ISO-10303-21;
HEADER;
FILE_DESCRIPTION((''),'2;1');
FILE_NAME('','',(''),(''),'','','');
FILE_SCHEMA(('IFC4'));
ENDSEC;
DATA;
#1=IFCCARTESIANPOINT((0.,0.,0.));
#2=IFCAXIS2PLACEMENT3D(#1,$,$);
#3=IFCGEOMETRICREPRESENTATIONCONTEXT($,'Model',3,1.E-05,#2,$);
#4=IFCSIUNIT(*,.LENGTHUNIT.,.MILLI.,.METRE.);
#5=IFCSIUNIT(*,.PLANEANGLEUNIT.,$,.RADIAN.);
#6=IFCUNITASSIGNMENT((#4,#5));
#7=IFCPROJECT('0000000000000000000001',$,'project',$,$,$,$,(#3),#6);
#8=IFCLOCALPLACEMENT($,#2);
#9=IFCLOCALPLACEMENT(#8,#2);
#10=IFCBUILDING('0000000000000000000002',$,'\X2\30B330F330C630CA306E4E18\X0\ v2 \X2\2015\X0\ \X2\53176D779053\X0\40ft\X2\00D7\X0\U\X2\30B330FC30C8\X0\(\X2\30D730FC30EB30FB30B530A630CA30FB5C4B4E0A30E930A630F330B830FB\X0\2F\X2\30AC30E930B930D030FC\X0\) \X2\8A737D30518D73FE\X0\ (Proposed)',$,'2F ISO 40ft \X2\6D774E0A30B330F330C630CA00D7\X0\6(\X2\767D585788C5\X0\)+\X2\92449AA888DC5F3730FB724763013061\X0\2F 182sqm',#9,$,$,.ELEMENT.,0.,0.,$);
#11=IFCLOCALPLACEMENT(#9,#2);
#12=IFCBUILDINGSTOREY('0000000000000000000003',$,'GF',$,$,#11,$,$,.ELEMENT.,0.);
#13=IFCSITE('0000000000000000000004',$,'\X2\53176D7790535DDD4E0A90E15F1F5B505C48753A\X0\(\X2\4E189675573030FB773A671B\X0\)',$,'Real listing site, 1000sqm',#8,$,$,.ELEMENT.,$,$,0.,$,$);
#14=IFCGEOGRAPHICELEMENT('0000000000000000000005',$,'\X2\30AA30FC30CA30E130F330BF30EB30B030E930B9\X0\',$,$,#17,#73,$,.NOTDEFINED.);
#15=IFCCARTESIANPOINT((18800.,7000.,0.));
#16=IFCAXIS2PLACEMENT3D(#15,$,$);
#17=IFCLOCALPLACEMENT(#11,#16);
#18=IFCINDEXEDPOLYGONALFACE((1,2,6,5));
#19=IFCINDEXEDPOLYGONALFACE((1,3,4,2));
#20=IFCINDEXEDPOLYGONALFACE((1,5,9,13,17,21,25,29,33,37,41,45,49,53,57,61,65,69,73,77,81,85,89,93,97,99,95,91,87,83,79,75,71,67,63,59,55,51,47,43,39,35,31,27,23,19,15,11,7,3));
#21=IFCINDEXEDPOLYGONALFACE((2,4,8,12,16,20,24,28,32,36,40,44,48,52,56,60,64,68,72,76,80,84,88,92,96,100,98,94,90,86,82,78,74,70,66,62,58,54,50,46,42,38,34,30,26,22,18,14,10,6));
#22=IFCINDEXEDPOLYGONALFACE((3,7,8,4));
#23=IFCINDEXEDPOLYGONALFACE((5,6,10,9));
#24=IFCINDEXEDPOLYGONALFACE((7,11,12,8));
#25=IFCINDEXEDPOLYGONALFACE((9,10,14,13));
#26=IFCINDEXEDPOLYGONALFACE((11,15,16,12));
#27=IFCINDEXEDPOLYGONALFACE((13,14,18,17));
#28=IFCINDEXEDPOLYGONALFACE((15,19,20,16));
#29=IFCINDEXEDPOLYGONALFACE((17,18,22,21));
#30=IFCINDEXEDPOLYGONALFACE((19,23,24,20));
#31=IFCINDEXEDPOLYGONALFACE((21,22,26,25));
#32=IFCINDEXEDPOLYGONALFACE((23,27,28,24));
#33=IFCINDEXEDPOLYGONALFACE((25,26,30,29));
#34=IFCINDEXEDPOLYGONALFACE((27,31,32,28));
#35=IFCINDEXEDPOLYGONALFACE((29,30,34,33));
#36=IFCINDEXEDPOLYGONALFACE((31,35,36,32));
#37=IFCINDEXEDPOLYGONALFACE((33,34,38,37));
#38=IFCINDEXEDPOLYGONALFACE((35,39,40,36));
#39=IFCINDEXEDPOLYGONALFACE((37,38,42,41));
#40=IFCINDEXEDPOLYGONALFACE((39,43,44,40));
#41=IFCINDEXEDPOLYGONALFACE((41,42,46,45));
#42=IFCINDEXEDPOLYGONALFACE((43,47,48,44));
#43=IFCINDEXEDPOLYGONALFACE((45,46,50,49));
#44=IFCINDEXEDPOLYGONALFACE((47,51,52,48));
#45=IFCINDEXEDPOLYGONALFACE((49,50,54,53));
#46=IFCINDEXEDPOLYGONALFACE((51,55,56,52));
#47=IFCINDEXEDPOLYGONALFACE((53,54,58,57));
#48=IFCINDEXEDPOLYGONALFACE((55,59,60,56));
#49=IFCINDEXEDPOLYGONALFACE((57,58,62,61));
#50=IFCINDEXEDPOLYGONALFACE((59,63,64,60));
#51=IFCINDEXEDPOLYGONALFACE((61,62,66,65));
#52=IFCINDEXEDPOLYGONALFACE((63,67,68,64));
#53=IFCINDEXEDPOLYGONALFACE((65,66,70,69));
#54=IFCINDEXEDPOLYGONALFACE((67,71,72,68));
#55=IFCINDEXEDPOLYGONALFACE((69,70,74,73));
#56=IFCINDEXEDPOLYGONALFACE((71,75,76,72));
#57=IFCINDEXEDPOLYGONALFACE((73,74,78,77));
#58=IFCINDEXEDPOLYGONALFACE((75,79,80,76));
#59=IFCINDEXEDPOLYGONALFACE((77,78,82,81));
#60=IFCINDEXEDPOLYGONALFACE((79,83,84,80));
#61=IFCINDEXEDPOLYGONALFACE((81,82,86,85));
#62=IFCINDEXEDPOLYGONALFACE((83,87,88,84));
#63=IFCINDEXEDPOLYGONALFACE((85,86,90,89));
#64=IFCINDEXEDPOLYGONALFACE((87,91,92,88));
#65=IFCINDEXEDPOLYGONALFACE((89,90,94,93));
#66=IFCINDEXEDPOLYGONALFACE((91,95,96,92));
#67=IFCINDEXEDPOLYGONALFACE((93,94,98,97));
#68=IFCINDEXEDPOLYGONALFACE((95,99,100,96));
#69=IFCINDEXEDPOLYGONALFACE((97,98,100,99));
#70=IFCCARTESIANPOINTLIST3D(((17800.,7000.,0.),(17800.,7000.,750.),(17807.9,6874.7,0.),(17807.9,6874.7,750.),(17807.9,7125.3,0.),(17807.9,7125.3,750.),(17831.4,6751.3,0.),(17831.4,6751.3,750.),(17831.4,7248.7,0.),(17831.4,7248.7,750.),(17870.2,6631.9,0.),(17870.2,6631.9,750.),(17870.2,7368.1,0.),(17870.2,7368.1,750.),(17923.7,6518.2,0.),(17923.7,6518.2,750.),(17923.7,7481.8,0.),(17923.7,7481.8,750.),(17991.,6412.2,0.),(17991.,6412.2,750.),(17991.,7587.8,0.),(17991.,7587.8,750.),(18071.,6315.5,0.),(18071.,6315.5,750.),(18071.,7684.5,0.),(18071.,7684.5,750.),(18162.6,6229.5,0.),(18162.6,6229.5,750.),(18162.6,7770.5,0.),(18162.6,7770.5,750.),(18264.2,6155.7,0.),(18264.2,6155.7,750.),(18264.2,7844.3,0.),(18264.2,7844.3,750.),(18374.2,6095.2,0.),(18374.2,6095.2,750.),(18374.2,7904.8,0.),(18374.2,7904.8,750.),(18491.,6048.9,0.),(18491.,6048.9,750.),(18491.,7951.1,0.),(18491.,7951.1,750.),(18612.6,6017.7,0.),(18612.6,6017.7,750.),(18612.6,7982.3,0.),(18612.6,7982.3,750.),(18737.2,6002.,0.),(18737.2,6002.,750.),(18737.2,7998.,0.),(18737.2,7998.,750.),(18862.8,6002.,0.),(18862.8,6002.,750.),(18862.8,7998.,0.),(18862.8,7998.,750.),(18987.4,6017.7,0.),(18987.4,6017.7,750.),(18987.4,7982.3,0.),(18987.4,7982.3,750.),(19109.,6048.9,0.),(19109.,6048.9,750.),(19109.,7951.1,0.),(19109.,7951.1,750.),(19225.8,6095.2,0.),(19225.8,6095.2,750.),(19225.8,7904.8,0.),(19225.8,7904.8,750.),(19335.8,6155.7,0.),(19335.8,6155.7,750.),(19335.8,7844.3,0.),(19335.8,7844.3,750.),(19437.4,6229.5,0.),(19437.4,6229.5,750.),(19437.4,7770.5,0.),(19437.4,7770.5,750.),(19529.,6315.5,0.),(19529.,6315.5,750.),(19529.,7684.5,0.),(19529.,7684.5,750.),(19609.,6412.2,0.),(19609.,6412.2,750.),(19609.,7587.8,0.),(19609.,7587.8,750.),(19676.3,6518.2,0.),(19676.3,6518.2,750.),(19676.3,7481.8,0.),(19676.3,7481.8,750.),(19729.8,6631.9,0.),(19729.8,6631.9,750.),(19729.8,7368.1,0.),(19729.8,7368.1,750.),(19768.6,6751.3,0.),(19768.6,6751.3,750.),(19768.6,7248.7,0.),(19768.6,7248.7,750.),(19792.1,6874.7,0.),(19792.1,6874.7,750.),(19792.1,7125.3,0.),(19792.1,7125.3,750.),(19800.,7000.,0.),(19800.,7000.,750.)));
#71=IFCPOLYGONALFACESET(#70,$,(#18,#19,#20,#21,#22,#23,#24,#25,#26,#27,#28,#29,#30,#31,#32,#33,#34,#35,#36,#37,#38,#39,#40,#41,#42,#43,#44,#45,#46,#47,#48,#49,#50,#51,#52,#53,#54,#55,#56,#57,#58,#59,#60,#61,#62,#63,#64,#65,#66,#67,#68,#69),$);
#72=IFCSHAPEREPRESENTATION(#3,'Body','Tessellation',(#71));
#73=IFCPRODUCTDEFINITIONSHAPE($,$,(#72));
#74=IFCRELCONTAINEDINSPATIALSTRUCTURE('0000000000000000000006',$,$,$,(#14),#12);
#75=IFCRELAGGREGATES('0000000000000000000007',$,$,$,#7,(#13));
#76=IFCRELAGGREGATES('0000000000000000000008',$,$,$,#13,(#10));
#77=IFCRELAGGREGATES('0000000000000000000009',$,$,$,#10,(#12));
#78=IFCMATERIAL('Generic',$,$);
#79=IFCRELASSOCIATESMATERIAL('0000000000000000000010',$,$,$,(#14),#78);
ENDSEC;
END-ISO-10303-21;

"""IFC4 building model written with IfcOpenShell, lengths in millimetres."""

from ifc_helpers import new_model, si_unit, frame, origin, origin_2d, place, context, project, spatial, circle, extrude, material, element, save


model = new_model("IFC4")

# Units and contexts
model_context = context("Model", 3, precision=1e-05, world=origin())
ifc_project = project(units=[si_unit("LENGTHUNIT", "METRE", prefix="MILLI"), si_unit("PLANEANGLEUNIT", "RADIAN")], contexts=[model_context])

# Site, building, storey
site_placement = place(None, origin())
site = spatial("IfcSite", under=ifc_project, at=site_placement, Name="北海道川上郡弟子屈町(丘陵地・眺望)", ObjectType="Real listing site, 1000sqm", CompositionType="ELEMENT", RefElevation=0.0)
building_placement = place(site_placement, origin())
building = spatial("IfcBuilding", under=site, at=building_placement, Name="コンテナの丘 v2 ― 北海道40ft×Uコート(プール・サウナ・屋上ラウンジ・2Fガラスバー) 詳細再現 (Proposed)", ObjectType="2F ISO 40ft 海上コンテナ×6(白塗装)+鉄骨補強・片持ち2F 182sqm", CompositionType="ELEMENT", ElevationOfRefHeight=0.0, ElevationOfTerrain=0.0)
storey_placement = place(building_placement, origin())
storey = spatial("IfcBuildingStorey", under=building, at=storey_placement, Name="GF", CompositionType="ELEMENT", Elevation=0.0)

# Shared definitions
ifc_material = material(Name="Generic")

# Geographic element
geographic_element_1_placement = place(storey_placement, frame((18800.0, 7000.0, 0.0)))
element("IfcGeographicElement", 1, at=geographic_element_1_placement, inside=storey, material=ifc_material, Name="オーナメンタルグラス", PredefinedType="NOTDEFINED", context=model_context, shape_type="SweptSolid", body=[
    extrude(circle(Radius=1000.0, at=origin_2d()), frame((18800.0, 7000.0, 0.0)), (0.0, 0.0, 1.0), 750.0),
])

save(model, "model.ifc")
